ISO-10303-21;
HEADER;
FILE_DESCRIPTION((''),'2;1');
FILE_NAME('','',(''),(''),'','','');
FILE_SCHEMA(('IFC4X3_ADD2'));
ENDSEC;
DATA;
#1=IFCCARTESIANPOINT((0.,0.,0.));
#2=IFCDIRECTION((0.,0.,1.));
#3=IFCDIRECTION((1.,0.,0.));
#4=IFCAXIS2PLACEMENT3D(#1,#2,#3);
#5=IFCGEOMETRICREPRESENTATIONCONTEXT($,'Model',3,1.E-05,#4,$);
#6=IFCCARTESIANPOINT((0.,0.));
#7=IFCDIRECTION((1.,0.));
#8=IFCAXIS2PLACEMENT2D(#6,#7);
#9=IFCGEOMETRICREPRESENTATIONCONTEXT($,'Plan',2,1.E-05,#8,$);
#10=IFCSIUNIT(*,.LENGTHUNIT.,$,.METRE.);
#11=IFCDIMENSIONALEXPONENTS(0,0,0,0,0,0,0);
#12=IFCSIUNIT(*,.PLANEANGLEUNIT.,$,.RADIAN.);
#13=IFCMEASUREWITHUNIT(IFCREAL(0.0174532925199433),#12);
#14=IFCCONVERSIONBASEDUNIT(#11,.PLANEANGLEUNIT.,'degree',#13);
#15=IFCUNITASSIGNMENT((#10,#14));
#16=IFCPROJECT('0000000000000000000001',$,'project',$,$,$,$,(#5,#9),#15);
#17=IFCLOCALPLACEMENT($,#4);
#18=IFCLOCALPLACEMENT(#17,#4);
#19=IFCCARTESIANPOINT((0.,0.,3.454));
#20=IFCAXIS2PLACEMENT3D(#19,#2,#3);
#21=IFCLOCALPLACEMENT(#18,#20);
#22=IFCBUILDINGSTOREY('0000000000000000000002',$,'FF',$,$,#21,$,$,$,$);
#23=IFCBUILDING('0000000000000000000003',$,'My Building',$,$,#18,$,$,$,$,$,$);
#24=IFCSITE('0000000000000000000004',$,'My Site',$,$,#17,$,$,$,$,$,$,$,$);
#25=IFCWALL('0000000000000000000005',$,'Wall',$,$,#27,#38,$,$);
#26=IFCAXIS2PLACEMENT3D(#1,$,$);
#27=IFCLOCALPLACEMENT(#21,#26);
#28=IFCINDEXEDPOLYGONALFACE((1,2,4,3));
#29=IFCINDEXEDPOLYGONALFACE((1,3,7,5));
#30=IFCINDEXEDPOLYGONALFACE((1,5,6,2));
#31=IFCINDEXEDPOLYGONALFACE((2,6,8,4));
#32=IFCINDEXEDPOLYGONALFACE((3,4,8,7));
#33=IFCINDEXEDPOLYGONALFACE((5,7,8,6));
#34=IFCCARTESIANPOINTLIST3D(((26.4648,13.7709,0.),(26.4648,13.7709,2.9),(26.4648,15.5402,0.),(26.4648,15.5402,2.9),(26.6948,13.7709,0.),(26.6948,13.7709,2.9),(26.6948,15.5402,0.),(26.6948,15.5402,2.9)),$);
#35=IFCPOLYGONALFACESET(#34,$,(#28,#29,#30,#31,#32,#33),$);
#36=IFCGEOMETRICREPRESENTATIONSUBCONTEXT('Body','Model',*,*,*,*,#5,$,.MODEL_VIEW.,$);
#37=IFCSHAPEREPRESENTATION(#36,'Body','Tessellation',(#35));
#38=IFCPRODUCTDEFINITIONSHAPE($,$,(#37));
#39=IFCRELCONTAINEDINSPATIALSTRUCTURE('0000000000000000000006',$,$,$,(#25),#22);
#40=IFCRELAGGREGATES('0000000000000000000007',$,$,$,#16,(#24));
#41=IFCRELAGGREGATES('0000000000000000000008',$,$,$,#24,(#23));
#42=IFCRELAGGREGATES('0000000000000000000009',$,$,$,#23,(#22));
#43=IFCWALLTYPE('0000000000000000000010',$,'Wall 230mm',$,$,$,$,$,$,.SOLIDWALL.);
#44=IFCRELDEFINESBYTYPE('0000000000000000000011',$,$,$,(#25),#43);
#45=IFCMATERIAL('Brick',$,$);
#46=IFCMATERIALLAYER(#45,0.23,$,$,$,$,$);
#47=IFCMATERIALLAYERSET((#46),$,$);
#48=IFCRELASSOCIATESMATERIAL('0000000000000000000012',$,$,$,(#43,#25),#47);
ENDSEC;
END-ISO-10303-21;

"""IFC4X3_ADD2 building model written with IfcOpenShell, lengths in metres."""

from ifc_helpers import new_model, entity, si_unit, converted_unit, frame, origin_with_axes, origin_2d_with_axis, place, context, subcontext, project, spatial, indexed_curve, outline, extrude, material, layer, layer_set, layer_usage, type_object, element, save


model = new_model("IFC4X3_ADD2")

# Units and contexts
model_context = context("Model", 3, precision=1e-05, world=origin_with_axes())
plan_context = context("Plan", 2, precision=1e-05, world=origin_2d_with_axis())
body_context = subcontext(model_context, "Body", "Model", "MODEL_VIEW")
ifc_project = project(units=[si_unit("LENGTHUNIT", "METRE"), converted_unit("PLANEANGLEUNIT", "degree", entity("IfcReal", 0.0174532925199433), si_unit("PLANEANGLEUNIT", "RADIAN"), dimensions=[0, 0, 0, 0, 0, 0, 0])], contexts=[model_context, plan_context])

# Site, building, storey
site_placement = place(None, origin_with_axes())
site = spatial("IfcSite", under=ifc_project, at=site_placement, Name="My Site")
building_placement = place(site_placement, origin_with_axes())
building = spatial("IfcBuilding", under=site, at=building_placement, Name="My Building")
storey_placement = place(building_placement, frame((0.0, 0.0, 3.454), z_axis=(0.0, 0.0, 1.0), x_axis=(1.0, 0.0, 0.0)))
storey = spatial("IfcBuildingStorey", under=building, at=storey_placement, Name="FF")

# Wall
ifc_material = material(Name="Brick")
ifc_layer_1 = layer(ifc_material, 0.23)
ifc_layer_set_1 = layer_set([ifc_layer_1])
wall_type_1 = type_object("IfcWallType", Name="Wall 230mm", PredefinedType="SOLIDWALL", material=ifc_layer_set_1)
ifc_layer_usage_1 = layer_usage(ifc_layer_set_1, "AXIS2", "POSITIVE", 0.0)
wall_1_placement = place(storey_placement, frame((26.6948, 13.7709, 0.0), z_axis=(0.0, 0.0, 1.0), x_axis=(0.000001, 1.0, 0.0)))
element("IfcWall", 1, at=wall_1_placement, inside=storey, type_object=wall_type_1, material=ifc_layer_usage_1, Name="Wall", context=body_context, shape_type="SweptSolid", body=[
    extrude(outline(indexed_curve([(0.0, 0.0), (0.0, 0.23), (1.7693, 0.23), (1.7693, 0.0), (0.0, 0.0)], self_intersect=False)), origin_with_axes(), (0.0, 0.0, 1.0), 2.9),
])

save(model, "model.ifc")
